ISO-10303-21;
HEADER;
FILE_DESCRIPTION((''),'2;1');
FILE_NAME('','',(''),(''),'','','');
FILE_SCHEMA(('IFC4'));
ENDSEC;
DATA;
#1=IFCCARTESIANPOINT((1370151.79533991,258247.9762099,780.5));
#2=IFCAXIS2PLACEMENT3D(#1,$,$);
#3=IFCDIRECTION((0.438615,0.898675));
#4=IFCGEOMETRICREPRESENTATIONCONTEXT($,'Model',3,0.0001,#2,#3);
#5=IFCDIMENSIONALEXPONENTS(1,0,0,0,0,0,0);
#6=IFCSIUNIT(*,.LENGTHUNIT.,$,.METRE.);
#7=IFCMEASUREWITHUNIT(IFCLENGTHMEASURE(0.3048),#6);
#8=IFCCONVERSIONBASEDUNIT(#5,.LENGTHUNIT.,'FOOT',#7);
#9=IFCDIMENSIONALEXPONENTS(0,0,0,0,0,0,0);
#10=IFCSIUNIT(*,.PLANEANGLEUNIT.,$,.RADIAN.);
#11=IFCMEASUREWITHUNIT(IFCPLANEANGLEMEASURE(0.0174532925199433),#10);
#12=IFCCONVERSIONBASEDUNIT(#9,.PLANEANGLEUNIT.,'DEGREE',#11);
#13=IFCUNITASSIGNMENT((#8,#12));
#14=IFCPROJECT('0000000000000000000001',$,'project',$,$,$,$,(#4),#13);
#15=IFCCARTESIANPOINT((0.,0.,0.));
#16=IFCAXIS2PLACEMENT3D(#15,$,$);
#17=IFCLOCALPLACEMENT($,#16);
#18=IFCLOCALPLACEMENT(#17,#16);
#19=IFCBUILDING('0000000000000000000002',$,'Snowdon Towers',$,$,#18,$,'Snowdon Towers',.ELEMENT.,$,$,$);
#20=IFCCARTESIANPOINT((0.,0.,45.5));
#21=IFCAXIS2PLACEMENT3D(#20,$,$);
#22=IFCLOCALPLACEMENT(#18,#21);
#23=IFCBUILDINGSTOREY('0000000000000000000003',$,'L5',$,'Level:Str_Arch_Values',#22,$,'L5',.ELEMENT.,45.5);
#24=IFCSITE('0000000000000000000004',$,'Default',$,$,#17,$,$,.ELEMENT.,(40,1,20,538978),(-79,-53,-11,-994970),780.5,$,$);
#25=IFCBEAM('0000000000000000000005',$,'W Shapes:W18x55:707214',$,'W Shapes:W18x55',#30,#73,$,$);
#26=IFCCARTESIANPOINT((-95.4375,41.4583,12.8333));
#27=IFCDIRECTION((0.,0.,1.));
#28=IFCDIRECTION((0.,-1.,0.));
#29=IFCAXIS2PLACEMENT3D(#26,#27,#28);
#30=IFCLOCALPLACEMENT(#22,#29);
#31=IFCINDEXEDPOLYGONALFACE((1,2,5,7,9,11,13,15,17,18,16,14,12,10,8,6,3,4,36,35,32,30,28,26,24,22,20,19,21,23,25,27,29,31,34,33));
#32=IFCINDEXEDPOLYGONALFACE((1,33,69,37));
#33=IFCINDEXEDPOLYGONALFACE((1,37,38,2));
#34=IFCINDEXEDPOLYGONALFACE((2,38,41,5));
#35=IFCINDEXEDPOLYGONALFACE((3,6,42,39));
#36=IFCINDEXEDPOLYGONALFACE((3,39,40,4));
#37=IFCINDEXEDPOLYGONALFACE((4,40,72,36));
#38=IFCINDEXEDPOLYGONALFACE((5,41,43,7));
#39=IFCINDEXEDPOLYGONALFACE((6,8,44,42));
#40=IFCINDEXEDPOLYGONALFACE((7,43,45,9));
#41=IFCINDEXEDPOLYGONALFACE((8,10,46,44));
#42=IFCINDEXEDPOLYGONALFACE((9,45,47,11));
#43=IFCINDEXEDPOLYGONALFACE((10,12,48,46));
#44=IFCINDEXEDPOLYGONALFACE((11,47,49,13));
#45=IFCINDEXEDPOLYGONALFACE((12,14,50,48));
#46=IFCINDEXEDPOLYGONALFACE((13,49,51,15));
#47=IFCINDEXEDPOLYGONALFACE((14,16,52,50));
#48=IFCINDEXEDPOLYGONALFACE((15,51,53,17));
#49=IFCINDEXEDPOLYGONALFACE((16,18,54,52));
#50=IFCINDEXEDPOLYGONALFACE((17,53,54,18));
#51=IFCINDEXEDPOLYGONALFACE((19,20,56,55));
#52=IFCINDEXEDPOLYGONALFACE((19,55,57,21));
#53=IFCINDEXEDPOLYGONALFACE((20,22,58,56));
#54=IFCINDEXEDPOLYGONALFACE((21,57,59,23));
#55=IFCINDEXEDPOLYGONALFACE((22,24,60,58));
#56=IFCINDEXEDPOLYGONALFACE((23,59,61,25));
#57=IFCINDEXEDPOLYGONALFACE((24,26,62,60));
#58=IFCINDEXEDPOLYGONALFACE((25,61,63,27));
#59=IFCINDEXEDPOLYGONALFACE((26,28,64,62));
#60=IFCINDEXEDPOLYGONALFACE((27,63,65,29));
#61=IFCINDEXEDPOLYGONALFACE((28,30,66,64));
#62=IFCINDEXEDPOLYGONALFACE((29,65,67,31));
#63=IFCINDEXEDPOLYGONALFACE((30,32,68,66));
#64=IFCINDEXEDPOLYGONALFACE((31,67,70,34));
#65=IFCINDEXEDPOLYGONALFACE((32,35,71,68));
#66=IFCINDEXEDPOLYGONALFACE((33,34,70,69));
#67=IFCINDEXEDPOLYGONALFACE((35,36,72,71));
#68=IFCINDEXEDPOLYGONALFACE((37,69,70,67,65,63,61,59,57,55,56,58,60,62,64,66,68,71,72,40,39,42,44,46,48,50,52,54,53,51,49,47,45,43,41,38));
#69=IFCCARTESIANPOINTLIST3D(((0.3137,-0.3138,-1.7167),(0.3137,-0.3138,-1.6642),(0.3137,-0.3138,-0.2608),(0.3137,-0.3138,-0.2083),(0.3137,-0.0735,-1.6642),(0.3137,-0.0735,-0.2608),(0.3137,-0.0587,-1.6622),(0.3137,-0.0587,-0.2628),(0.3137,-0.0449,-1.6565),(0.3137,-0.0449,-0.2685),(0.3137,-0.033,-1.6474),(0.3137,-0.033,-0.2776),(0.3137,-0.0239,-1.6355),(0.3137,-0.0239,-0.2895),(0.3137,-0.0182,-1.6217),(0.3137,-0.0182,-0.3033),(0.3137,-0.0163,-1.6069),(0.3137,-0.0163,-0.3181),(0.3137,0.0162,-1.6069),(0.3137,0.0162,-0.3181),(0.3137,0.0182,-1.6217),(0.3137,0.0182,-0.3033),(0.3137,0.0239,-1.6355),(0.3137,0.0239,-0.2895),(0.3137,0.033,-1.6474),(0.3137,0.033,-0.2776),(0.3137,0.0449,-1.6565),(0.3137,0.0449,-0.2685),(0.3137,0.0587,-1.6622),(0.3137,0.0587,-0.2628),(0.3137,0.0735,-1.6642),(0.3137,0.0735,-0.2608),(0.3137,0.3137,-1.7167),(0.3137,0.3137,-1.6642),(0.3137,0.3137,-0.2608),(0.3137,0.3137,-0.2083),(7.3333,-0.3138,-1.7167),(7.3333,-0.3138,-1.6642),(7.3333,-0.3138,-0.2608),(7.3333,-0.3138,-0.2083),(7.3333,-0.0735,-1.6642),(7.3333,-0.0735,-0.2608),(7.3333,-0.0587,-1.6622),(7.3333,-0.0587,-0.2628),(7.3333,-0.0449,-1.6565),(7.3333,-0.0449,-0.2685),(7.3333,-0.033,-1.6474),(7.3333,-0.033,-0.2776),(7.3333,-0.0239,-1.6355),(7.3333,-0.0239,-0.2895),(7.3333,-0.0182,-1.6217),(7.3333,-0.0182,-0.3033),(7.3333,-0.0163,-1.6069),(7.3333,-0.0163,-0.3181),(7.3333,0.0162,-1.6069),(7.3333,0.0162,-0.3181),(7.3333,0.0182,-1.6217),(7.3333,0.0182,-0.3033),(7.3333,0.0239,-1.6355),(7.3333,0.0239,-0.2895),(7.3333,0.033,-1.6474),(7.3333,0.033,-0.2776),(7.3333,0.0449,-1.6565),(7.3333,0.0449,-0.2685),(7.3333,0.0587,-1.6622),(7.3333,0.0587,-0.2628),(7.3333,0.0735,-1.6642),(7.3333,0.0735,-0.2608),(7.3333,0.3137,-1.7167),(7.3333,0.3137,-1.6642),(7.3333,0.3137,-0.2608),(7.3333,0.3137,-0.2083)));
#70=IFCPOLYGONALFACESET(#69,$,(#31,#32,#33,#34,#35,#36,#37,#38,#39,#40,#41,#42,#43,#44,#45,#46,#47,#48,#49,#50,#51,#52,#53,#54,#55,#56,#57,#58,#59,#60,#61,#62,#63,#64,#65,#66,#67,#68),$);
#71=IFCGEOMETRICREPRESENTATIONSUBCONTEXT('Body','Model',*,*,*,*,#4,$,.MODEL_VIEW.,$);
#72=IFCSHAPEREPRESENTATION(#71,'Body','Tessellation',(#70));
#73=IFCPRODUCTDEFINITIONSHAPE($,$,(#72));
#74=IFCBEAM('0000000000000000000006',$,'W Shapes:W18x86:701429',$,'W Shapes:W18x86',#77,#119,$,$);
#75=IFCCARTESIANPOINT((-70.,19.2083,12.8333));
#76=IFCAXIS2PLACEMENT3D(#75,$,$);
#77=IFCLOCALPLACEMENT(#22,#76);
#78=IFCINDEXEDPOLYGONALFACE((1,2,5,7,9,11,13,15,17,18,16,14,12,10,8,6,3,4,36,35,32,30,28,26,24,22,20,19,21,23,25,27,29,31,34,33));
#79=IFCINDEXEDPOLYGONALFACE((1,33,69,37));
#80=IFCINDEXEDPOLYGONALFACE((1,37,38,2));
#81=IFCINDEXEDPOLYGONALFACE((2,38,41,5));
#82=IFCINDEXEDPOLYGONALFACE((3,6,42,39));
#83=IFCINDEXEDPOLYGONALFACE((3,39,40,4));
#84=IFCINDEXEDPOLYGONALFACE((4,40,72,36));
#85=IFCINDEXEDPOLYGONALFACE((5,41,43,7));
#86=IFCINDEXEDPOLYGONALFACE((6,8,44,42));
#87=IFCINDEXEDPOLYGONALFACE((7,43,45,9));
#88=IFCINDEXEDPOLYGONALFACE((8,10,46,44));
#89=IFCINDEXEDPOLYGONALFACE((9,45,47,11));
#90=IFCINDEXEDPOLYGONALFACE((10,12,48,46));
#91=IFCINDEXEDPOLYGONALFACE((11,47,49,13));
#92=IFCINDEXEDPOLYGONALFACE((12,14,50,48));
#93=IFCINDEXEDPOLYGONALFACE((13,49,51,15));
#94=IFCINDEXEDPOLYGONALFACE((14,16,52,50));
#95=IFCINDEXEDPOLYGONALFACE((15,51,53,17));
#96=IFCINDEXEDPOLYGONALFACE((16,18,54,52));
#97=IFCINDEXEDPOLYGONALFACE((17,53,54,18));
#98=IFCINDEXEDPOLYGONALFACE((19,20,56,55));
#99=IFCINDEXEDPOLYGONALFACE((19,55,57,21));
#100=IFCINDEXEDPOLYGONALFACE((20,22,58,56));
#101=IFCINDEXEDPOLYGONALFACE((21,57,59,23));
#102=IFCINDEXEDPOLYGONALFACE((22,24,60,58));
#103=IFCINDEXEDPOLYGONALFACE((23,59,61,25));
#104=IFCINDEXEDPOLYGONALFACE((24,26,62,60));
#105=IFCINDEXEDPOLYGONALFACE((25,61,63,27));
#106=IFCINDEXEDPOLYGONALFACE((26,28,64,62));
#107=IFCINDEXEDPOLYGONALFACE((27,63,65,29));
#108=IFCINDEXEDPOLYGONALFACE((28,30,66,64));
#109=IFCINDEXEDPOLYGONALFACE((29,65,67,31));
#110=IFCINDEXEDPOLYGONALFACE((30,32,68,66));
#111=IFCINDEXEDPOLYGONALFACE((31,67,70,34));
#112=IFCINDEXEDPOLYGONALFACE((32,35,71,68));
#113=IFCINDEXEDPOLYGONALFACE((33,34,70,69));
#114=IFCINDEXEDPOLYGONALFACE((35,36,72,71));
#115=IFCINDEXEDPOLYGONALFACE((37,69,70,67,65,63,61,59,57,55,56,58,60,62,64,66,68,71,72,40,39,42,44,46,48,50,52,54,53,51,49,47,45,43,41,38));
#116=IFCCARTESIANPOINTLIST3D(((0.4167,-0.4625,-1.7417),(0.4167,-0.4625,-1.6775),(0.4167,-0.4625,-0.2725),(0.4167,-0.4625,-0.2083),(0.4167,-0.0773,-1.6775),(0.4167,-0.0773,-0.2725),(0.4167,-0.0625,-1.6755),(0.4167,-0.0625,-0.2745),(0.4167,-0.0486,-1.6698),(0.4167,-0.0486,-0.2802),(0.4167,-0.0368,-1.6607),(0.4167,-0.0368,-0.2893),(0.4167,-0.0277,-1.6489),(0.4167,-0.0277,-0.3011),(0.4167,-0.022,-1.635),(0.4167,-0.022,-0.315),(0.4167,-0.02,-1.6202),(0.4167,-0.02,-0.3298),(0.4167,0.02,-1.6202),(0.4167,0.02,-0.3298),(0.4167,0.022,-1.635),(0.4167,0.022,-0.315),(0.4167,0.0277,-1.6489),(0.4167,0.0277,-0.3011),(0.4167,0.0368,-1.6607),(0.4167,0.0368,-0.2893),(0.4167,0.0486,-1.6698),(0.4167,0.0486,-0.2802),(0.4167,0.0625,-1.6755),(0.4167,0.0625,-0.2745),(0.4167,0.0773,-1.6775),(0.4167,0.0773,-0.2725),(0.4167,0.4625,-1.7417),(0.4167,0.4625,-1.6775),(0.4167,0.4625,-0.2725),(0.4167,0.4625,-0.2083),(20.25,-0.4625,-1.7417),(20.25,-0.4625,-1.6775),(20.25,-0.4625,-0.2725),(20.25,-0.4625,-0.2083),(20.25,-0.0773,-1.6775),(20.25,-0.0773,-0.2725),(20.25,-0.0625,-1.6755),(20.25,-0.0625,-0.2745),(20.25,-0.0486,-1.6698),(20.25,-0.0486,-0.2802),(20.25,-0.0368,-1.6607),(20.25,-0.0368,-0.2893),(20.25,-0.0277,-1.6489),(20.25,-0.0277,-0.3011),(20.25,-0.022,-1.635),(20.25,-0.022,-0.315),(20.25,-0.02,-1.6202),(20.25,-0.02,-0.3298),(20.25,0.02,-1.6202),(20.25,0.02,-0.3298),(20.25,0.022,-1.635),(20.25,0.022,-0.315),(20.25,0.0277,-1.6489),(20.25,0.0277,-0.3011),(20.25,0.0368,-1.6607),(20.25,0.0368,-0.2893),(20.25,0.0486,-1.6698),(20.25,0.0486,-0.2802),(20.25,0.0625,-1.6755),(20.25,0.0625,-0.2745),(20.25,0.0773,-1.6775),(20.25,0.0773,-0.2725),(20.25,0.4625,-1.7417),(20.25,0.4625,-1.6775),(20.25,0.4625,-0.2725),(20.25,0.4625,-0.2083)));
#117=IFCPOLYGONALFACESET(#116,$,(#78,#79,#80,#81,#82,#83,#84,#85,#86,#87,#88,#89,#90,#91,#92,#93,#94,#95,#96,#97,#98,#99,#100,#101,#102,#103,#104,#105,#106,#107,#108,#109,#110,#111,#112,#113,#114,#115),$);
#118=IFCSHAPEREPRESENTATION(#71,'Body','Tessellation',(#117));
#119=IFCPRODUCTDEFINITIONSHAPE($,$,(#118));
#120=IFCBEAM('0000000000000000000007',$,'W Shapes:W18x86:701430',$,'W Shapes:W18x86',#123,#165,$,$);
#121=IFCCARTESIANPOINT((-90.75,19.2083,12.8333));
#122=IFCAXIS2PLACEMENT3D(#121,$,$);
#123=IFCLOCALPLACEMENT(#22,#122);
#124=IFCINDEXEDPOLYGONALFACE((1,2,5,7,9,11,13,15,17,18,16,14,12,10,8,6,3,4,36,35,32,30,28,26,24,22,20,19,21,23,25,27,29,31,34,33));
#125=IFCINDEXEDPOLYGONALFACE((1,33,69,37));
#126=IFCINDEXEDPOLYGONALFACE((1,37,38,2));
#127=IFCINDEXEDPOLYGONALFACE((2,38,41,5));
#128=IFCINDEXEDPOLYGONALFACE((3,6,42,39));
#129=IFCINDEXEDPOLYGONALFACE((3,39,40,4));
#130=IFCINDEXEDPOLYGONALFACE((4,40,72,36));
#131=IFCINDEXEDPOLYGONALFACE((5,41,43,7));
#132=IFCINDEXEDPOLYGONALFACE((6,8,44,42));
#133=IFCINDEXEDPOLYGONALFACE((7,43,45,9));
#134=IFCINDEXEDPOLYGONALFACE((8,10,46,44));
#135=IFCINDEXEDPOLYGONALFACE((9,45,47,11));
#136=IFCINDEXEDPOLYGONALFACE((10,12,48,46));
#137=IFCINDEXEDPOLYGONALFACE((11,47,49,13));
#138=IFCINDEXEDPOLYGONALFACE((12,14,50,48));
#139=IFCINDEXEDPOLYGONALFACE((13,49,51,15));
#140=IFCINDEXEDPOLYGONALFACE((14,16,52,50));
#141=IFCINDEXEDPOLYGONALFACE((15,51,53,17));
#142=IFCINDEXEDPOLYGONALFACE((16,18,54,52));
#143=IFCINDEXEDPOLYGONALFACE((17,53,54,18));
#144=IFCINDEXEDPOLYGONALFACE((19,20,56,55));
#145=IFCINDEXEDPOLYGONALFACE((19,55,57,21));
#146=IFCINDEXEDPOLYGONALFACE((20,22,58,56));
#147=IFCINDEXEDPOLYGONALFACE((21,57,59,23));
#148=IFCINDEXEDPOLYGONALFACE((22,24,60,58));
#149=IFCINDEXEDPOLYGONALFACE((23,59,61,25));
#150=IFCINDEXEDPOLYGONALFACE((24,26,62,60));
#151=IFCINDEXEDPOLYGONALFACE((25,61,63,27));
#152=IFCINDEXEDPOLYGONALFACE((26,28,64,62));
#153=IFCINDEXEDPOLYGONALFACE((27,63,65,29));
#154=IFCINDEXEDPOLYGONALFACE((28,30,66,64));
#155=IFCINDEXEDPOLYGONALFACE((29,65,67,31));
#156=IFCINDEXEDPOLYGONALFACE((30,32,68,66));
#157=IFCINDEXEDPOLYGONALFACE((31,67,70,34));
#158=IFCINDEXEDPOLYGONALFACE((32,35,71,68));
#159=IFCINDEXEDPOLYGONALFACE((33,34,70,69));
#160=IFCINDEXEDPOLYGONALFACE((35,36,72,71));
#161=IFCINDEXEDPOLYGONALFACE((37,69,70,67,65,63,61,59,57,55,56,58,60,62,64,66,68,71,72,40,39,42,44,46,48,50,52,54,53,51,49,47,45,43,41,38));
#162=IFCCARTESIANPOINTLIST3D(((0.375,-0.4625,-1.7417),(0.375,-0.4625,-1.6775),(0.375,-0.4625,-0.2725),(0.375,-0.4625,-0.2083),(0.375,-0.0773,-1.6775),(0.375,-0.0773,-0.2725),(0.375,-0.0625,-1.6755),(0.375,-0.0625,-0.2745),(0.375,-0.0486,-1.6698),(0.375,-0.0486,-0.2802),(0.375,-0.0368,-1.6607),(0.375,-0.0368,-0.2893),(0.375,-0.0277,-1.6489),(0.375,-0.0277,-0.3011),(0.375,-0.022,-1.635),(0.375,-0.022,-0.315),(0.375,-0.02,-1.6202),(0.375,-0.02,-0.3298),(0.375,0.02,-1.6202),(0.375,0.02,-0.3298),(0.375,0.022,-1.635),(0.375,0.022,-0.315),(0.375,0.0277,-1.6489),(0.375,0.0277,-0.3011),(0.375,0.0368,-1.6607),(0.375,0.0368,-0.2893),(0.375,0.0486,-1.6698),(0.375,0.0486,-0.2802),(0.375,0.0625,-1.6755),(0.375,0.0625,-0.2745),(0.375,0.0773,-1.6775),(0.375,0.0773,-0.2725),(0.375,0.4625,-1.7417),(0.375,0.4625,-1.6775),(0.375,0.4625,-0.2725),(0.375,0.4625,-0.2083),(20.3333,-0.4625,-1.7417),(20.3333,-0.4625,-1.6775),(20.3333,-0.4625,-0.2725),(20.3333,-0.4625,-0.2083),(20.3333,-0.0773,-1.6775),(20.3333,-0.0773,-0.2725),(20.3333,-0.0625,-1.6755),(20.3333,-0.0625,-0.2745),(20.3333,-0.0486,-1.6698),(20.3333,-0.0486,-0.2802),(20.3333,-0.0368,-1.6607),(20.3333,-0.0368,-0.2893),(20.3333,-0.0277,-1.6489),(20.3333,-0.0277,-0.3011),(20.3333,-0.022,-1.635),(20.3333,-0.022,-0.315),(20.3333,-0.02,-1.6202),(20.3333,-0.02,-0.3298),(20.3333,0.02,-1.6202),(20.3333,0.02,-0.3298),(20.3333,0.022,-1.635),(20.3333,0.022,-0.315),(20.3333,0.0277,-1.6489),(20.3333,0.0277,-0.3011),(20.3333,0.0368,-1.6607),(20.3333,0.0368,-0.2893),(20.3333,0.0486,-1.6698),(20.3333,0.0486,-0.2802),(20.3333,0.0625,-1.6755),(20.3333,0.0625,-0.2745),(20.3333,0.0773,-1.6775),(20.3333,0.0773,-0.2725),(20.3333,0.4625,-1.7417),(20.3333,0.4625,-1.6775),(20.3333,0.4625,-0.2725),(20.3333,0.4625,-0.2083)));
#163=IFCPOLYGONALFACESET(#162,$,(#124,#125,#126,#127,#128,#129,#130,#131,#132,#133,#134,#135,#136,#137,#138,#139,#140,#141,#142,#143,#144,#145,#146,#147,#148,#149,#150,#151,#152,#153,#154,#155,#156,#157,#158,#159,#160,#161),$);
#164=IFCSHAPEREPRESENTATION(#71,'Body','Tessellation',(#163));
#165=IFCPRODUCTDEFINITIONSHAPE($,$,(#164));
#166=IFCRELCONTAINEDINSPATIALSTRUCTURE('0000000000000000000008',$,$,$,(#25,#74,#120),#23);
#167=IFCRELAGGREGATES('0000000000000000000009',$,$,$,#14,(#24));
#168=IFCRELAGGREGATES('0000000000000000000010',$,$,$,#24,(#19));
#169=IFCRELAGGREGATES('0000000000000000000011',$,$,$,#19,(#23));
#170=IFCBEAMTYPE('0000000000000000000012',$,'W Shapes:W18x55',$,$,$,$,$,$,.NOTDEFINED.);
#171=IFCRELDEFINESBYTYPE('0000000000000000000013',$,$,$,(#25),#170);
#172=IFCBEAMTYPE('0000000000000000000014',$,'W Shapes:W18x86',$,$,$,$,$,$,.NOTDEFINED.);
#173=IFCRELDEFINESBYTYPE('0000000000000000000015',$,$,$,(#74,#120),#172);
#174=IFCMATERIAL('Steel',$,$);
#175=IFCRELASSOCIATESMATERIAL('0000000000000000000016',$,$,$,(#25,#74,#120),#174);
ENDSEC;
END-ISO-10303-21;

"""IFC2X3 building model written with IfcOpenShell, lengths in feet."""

from ifc_helpers import new_model, entity, si_unit, converted_unit, direction, frame, frame_2d, origin, place, context, subcontext, project, spatial, i_section, extrude, material, type_object, element, save


model = new_model("IFC2X3")

# Units and contexts
model_context = context("Model", 3, precision=0.0001, world=frame((1370151.79533991, 258247.9762099, 780.5)), true_north=direction((0.438615, 0.898675)))
body_context = subcontext(model_context, "Body", "Model", "MODEL_VIEW")
ifc_project = project(units=[converted_unit("LENGTHUNIT", "FOOT", entity("IfcLengthMeasure", 0.3048), si_unit("LENGTHUNIT", "METRE"), dimensions=[1, 0, 0, 0, 0, 0, 0]), converted_unit("PLANEANGLEUNIT", "DEGREE", entity("IfcPlaneAngleMeasure", 0.0174532925199433), si_unit("PLANEANGLEUNIT", "RADIAN"), dimensions=[0, 0, 0, 0, 0, 0, 0])], contexts=[model_context])

# Site, building, storey
site_placement = place(None, origin())
site = spatial("IfcSite", under=ifc_project, at=site_placement, Name="Default", CompositionType="ELEMENT", RefLatitude=(40, 1, 20, 538978), RefLongitude=(-79, -53, -11, -994970), RefElevation=780.5)
building_placement = place(site_placement, origin())
building = spatial("IfcBuilding", under=site, at=building_placement, Name="Snowdon Towers", LongName="Snowdon Towers", CompositionType="ELEMENT")
storey_placement = place(building_placement, frame((0.0, 0.0, 45.5)))
storey = spatial("IfcBuildingStorey", under=building, at=storey_placement, Name="L5", ObjectType="Level:Str_Arch_Values", LongName="L5", CompositionType="ELEMENT", Elevation=45.5)

# Beam
ifc_material = material(Name="Steel")
beam_type_1 = type_object("IfcBeamType", Name="W Shapes:W18x55", PredefinedType="NOTDEFINED")
beam_1_placement = place(storey_placement, frame((-95.4375, 41.4583, 12.8333), z_axis=(0.0, 0.0, 1.0), x_axis=(0.0, -1.0, 0.0)))
element("IfcBeam", 1, at=beam_1_placement, inside=storey, type_object=beam_type_1, material=ifc_material, Name="W Shapes:W18x55:707214", ObjectType="W Shapes:W18x55", context=body_context, shape_type="SweptSolid", body=[
    extrude(i_section(OverallWidth=0.6275, OverallDepth=1.5083, WebThickness=0.0325, FlangeThickness=0.0525, FilletRadius=0.0573, at=frame_2d((0.0, 0.0), x_axis=(0.0, 1.0))), frame((0.3137, 0.0, -0.9625), z_axis=(1.0, 0.0, 0.0), x_axis=(0.0, 0.0, -1.0)), (0.0, 0.0, 1.0), 7.0196),
])

# Beams
beam_type_2 = type_object("IfcBeamType", Name="W Shapes:W18x86", PredefinedType="NOTDEFINED")
beam_2_placement = place(storey_placement, frame((-70.0, 19.2083, 12.8333)))
element("IfcBeam", 2, at=beam_2_placement, inside=storey, type_object=beam_type_2, material=ifc_material, Name="W Shapes:W18x86:701429", ObjectType="W Shapes:W18x86", context=body_context, shape_type="SweptSolid", body=[
    extrude(i_section(OverallWidth=0.925, OverallDepth=1.5333, WebThickness=0.04, FlangeThickness=0.0642, FilletRadius=0.0573, at=frame_2d((0.0, 0.0), x_axis=(0.0, 1.0))), frame((0.4167, 0.0, -0.975), z_axis=(1.0, 0.0, 0.0), x_axis=(0.0, 0.0, -1.0)), (0.0, 0.0, 1.0), 19.8333),
])
beam_3_placement = place(storey_placement, frame((-90.75, 19.2083, 12.8333)))
element("IfcBeam", 3, at=beam_3_placement, inside=storey, type_object=beam_type_2, material=ifc_material, Name="W Shapes:W18x86:701430", ObjectType="W Shapes:W18x86", context=body_context, shape_type="SweptSolid", body=[
    extrude(i_section(OverallWidth=0.925, OverallDepth=1.5333, WebThickness=0.04, FlangeThickness=0.0642, FilletRadius=0.0573, at=frame_2d((0.0, 0.0), x_axis=(0.0, 1.0))), frame((0.375, 0.0, -0.975), z_axis=(1.0, 0.0, 0.0), x_axis=(0.0, 0.0, -1.0)), (0.0, 0.0, 1.0), 19.9583),
])

save(model, "model.ifc")
